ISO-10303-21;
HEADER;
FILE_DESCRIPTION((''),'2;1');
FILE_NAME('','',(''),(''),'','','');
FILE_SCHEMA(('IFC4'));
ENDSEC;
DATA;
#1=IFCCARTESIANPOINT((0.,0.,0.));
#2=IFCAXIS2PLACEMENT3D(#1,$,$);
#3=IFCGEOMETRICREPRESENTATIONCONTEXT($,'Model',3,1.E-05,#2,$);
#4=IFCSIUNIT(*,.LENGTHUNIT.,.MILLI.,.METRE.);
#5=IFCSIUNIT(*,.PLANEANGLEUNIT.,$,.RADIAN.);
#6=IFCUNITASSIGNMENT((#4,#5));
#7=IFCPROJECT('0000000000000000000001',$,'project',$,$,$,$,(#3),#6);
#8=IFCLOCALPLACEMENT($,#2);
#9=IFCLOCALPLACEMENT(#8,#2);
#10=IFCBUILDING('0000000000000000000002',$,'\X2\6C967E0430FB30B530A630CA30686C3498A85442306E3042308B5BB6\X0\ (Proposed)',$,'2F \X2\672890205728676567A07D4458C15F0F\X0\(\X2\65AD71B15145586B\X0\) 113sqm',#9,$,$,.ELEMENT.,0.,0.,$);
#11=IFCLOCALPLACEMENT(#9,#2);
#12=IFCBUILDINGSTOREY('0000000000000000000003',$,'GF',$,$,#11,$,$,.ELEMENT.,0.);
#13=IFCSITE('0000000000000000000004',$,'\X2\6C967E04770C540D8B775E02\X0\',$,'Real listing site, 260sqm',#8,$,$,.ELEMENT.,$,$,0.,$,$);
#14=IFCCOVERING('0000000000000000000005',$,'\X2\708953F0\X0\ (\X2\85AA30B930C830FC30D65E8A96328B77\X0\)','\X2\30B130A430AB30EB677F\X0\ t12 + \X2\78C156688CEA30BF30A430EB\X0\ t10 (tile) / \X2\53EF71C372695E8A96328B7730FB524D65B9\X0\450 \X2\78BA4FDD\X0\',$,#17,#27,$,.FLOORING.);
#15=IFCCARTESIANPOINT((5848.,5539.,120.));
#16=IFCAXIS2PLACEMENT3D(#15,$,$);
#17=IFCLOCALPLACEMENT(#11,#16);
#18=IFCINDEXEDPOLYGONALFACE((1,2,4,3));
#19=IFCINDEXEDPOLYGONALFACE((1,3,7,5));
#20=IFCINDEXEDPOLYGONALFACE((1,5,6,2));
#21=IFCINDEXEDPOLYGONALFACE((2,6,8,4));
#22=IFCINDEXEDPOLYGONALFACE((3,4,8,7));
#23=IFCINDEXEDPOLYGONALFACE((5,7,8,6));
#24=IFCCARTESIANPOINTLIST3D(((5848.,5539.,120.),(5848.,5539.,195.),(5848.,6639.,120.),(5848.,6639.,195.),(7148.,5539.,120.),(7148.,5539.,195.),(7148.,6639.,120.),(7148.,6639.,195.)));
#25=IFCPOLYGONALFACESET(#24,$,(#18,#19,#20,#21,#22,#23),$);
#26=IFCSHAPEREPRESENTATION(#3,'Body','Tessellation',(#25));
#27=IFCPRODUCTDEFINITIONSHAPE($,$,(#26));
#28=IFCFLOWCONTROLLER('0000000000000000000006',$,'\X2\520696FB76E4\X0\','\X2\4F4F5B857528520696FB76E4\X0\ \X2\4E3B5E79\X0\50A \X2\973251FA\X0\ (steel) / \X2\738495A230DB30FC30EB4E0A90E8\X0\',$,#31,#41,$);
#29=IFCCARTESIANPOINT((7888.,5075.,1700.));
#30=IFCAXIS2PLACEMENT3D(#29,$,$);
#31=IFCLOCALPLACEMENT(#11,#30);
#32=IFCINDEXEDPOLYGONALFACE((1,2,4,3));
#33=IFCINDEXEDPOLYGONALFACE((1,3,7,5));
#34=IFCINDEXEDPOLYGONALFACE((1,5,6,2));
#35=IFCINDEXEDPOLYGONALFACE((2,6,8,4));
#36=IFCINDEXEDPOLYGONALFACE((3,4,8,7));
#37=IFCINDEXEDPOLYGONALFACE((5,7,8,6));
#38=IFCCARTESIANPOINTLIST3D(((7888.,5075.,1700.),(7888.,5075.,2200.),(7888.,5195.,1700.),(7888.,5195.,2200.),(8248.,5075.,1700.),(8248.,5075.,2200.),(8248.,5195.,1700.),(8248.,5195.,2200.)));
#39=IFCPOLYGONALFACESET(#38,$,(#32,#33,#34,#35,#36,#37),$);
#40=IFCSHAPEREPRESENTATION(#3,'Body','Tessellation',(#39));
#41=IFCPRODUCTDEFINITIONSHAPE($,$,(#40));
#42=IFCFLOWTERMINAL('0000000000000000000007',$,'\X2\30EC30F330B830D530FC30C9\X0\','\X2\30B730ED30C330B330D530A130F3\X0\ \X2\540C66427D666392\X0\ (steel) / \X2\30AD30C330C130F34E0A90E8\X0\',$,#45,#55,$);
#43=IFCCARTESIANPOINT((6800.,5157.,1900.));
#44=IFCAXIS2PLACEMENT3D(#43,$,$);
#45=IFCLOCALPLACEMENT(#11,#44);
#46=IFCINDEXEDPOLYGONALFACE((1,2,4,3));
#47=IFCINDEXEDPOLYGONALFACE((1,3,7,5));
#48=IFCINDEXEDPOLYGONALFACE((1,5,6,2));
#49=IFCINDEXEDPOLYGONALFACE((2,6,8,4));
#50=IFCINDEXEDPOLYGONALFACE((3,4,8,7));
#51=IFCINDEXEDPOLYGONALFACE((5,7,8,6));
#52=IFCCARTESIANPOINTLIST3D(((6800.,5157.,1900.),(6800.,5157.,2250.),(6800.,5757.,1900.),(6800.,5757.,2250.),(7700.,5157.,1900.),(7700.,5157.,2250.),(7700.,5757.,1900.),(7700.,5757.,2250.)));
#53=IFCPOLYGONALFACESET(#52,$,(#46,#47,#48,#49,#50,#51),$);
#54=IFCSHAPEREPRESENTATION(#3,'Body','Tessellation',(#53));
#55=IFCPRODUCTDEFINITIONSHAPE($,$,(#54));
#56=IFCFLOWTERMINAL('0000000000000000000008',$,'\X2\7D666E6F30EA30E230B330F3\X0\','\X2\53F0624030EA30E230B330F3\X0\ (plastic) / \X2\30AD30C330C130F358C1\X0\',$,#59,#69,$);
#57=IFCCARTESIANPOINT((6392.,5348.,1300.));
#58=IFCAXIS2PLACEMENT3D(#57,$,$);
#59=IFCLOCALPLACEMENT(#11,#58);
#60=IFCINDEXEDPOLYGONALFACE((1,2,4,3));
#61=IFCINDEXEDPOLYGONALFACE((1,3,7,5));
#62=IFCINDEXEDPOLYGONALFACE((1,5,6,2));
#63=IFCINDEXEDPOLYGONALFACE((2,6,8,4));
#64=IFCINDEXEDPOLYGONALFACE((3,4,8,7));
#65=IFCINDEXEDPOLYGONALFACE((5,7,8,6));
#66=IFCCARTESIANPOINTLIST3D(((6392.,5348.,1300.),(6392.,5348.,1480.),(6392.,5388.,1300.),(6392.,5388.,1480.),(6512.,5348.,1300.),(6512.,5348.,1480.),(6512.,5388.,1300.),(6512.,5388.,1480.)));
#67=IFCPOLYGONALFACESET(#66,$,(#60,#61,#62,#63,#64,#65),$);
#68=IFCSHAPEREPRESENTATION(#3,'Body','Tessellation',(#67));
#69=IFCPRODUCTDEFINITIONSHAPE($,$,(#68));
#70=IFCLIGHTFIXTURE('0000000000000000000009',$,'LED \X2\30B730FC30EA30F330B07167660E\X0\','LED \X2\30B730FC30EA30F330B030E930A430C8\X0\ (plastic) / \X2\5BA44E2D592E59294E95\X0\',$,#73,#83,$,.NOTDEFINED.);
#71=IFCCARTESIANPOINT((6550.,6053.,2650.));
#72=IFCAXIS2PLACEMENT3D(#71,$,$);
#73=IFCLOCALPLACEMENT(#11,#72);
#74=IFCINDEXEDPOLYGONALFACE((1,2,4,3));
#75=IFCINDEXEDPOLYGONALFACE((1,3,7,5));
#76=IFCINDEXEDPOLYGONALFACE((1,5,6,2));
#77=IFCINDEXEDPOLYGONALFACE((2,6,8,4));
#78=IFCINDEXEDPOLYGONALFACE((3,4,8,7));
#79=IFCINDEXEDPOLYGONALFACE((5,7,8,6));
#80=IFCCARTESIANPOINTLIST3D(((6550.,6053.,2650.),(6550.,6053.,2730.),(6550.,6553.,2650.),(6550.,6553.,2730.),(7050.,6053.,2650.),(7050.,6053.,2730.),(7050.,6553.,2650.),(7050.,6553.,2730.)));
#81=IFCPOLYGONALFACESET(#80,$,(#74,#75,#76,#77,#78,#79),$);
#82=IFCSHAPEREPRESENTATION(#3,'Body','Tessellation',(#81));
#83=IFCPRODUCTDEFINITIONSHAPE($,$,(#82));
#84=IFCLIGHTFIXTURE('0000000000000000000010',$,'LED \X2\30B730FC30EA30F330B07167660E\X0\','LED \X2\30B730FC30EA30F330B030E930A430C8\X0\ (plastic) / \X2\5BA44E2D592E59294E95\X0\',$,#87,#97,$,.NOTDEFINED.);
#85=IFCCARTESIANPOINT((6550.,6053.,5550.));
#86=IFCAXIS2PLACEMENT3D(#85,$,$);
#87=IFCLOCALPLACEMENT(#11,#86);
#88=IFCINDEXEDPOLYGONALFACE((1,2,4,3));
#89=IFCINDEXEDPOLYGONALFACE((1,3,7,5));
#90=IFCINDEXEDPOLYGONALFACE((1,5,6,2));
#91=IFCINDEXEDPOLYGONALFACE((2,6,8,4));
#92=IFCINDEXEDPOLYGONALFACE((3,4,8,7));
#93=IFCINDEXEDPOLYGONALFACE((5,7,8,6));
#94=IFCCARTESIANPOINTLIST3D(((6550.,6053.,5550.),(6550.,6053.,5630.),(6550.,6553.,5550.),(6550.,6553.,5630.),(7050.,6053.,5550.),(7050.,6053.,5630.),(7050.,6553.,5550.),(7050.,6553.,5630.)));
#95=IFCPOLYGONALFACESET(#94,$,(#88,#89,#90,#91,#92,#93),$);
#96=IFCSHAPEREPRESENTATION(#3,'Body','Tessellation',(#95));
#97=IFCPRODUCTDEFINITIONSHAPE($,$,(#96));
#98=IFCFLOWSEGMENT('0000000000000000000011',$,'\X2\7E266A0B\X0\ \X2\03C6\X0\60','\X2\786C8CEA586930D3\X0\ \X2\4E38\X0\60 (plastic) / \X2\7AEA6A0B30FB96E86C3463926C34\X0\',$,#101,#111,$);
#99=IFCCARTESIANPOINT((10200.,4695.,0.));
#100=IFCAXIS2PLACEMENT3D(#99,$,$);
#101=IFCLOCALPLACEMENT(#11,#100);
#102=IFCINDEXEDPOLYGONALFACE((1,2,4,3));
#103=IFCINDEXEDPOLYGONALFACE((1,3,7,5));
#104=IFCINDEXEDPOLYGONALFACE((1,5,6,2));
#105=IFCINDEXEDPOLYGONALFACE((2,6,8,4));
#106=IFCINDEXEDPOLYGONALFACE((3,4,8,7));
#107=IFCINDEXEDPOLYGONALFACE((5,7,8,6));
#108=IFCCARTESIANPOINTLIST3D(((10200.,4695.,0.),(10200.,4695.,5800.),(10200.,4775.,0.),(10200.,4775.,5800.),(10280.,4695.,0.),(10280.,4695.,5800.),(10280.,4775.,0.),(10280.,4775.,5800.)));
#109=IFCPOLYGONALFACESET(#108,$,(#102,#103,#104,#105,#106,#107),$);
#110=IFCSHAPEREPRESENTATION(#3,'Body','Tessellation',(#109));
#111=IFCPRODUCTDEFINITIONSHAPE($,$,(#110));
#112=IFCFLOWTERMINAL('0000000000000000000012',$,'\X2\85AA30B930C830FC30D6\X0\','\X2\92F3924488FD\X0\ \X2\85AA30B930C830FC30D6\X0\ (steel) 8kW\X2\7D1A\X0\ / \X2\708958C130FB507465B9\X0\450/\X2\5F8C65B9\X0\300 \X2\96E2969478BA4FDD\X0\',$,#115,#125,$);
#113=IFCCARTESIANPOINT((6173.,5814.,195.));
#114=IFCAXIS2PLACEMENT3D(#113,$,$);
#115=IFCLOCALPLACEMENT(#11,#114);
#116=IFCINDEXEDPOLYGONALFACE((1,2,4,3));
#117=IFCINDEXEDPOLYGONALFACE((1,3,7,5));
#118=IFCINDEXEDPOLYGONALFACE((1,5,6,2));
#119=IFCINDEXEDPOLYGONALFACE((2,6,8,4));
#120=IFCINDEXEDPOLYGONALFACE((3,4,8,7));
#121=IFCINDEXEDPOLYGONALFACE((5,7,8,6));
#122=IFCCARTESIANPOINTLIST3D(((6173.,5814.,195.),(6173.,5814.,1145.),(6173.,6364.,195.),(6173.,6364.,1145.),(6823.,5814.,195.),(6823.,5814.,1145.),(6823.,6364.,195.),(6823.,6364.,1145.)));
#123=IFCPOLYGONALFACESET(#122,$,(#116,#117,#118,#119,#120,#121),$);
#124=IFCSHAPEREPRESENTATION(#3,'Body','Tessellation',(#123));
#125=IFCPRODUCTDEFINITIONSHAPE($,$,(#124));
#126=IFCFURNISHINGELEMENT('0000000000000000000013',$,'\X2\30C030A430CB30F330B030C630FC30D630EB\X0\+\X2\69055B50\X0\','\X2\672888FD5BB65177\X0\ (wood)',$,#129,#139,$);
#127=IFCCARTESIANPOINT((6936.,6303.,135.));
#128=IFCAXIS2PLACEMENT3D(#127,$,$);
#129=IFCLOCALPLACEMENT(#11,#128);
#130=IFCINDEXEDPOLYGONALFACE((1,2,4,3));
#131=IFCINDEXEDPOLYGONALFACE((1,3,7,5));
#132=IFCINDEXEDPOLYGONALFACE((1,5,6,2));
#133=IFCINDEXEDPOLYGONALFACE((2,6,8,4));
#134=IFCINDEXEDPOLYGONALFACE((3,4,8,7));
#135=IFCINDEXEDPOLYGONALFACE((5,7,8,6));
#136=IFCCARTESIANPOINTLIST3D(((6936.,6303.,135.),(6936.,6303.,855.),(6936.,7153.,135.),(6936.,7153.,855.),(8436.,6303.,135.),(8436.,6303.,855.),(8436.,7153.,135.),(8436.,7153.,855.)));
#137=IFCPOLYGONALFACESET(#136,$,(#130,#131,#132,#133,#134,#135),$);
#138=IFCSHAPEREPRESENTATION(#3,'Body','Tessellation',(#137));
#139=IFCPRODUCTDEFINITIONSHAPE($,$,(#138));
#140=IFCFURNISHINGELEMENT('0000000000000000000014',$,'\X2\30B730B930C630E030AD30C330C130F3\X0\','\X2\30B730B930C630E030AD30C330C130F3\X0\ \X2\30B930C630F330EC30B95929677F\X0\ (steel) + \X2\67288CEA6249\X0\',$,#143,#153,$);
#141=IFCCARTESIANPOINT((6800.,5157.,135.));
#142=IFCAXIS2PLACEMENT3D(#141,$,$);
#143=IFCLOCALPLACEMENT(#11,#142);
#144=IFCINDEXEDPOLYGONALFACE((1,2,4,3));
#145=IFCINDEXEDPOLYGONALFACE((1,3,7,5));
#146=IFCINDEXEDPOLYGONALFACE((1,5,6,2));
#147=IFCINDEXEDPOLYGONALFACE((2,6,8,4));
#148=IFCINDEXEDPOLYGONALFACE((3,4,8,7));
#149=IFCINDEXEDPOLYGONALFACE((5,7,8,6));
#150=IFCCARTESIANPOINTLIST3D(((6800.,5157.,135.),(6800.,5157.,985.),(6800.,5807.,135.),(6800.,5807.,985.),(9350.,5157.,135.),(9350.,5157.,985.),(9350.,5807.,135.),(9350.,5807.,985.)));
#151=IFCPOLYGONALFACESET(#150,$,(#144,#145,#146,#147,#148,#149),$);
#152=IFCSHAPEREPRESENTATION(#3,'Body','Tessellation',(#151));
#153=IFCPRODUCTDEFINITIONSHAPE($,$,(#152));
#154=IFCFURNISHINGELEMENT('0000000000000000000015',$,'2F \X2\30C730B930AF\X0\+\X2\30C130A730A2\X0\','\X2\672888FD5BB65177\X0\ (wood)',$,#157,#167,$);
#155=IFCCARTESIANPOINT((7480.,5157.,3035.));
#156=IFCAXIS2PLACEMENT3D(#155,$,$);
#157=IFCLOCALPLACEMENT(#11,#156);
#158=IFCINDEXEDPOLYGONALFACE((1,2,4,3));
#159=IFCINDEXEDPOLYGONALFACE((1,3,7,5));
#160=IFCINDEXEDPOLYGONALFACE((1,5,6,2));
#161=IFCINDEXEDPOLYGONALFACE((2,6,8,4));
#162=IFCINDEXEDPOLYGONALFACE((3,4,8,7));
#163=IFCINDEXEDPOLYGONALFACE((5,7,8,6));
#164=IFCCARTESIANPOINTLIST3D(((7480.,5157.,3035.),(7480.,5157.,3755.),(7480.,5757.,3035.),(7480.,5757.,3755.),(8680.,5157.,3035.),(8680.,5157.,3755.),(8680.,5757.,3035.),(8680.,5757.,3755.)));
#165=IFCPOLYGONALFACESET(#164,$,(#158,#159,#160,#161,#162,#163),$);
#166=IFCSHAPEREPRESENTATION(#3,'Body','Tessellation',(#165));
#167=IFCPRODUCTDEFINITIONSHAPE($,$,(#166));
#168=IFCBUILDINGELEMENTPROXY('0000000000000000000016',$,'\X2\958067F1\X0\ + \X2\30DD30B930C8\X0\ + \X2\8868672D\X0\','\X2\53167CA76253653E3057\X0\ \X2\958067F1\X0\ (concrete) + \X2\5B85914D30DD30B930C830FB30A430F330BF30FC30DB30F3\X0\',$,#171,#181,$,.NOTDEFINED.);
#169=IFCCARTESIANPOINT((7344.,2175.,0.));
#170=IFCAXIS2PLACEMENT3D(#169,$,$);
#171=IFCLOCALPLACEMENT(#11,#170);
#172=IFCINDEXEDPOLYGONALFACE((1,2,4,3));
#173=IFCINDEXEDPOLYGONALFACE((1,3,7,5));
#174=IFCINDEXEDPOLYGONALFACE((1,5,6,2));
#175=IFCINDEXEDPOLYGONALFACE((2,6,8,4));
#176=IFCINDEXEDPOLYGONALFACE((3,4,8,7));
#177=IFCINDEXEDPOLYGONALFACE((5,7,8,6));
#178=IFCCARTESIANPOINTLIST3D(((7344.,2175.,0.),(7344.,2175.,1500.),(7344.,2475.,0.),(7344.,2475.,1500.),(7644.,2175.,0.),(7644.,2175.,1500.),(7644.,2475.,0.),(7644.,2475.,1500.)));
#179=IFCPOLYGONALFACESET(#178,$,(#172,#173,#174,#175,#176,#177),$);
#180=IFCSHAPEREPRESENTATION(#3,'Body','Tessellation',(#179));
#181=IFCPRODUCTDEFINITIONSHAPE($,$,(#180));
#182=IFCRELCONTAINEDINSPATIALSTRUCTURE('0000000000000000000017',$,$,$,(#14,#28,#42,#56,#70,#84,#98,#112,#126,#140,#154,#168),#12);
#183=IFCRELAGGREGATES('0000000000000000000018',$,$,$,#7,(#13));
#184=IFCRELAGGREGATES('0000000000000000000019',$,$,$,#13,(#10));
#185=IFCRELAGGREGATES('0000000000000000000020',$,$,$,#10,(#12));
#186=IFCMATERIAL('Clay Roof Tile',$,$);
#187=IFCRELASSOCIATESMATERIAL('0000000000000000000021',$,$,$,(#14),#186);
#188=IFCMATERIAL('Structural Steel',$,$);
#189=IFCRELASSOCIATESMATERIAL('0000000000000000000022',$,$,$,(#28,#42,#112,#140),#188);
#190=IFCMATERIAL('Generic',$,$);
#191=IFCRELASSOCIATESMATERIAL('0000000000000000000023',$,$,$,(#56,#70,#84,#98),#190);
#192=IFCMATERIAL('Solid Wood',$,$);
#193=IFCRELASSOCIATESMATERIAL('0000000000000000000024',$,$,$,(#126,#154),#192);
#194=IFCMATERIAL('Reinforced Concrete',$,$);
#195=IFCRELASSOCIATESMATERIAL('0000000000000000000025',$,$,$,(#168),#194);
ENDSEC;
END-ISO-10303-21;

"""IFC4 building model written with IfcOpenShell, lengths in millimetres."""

from ifc_helpers import new_model, si_unit, frame, frame_2d, origin, place, context, project, spatial, rectangle, extrude, material, element, save


model = new_model("IFC4")

# Units and contexts
model_context = context("Model", 3, precision=1e-05, world=origin())
ifc_project = project(units=[si_unit("LENGTHUNIT", "METRE", prefix="MILLI"), si_unit("PLANEANGLEUNIT", "RADIAN")], contexts=[model_context])

# Site, building, storey
site_placement = place(None, origin())
site = spatial("IfcSite", under=ifc_project, at=site_placement, Name="沖縄県名護市", ObjectType="Real listing site, 260sqm", CompositionType="ELEMENT", RefElevation=0.0)
building_placement = place(site_placement, origin())
building = spatial("IfcBuilding", under=site, at=building_placement, Name="沖縄・サウナと水風呂のある家 (Proposed)", ObjectType="2F 木造在来枠組壁式(断熱充填) 113sqm", CompositionType="ELEMENT", ElevationOfRefHeight=0.0, ElevationOfTerrain=0.0)
storey_placement = place(building_placement, origin())
storey = spatial("IfcBuildingStorey", under=building, at=storey_placement, Name="GF", CompositionType="ELEMENT", Elevation=0.0)

# Shared definitions
ifc_material_1 = material(Name="Solid Wood")

# Shared definitions
ifc_material_2 = material(Name="Structural Steel")

# Covering
ifc_material_3 = material(Name="Reinforced Concrete")
ifc_material_4 = material(Name="Clay Roof Tile")
covering_1_placement = place(storey_placement, frame((5848.0, 5539.0, 120.0)))
element("IfcCovering", 1, at=covering_1_placement, inside=storey, material=ifc_material_4, Name="炉台 (薪ストーブ床防護)", Description="ケイカル板 t12 + 磁器質タイル t10 (tile) / 可燃物床防護・前方450 確保", PredefinedType="FLOORING", context=model_context, shape_type="SweptSolid", body=[
    extrude(rectangle(XDim=1300.0, YDim=1100.0, at=frame_2d((650.0, 550.0))), frame((5848.0, 5539.0, 120.0)), (0.0, 0.0, 1.0), 75.0),
])

# Flow controller
flow_controller_placement = place(storey_placement, frame((7888.0, 5075.0, 1700.0)))
element("IfcFlowController", 2, at=flow_controller_placement, inside=storey, material=ifc_material_2, Name="分電盤", Description="住宅用分電盤 主幹50A 露出 (steel) / 玄関ホール上部", context=model_context, shape_type="SweptSolid", body=[
    extrude(rectangle(XDim=360.0, YDim=120.0, at=frame_2d((180.0, 60.0))), frame((7888.0, 5075.0, 1700.0)), (0.0, 0.0, 1.0), 500.0),
])

# Flow terminals
flow_terminal_1_placement = place(storey_placement, frame((6800.0, 5157.0, 1900.0)))
element("IfcFlowTerminal", 3, at=flow_terminal_1_placement, inside=storey, material=ifc_material_2, Name="レンジフード", Description="シロッコファン 同時給排 (steel) / キッチン上部", context=model_context, shape_type="SweptSolid", body=[
    extrude(rectangle(XDim=900.0, YDim=600.0, at=frame_2d((450.0, 300.0))), frame((6800.0, 5157.0, 1900.0)), (0.0, 0.0, 1.0), 350.0),
])
ifc_material_5 = material(Name="Generic")
flow_terminal_2_placement = place(storey_placement, frame((6392.0, 5348.0, 1300.0)))
element("IfcFlowTerminal", 4, at=flow_terminal_2_placement, inside=storey, material=ifc_material_5, Name="給湯リモコン", Description="台所リモコン (plastic) / キッチン壁", context=model_context, shape_type="SweptSolid", body=[
    extrude(rectangle(XDim=120.0, YDim=40.0, at=frame_2d((60.0, 20.0))), frame((6392.0, 5348.0, 1300.0)), (0.0, 0.0, 1.0), 180.0),
])

# Light fixtures
light_fixture_1_placement = place(storey_placement, frame((6550.0, 6053.0, 2650.0)))
element("IfcLightFixture", 5, at=light_fixture_1_placement, inside=storey, material=ifc_material_5, Name="LED シーリング照明", Description="LED シーリングライト (plastic) / 室中央天井", PredefinedType="NOTDEFINED", context=model_context, shape_type="SweptSolid", body=[
    extrude(rectangle(XDim=500.0, YDim=500.0, at=frame_2d((250.0, 250.0))), frame((6550.0, 6053.0, 2650.0)), (0.0, 0.0, 1.0), 80.0),
])
light_fixture_2_placement = place(storey_placement, frame((6550.0, 6053.0, 5550.0)))
element("IfcLightFixture", 6, at=light_fixture_2_placement, inside=storey, material=ifc_material_5, Name="LED シーリング照明", Description="LED シーリングライト (plastic) / 室中央天井", PredefinedType="NOTDEFINED", context=model_context, shape_type="SweptSolid", body=[
    extrude(rectangle(XDim=500.0, YDim=500.0, at=frame_2d((250.0, 250.0))), frame((6550.0, 6053.0, 5550.0)), (0.0, 0.0, 1.0), 80.0),
])

# Flow segment
flow_segment_placement = place(storey_placement, frame((10200.0, 4695.0, 0.0)))
element("IfcFlowSegment", 7, at=flow_segment_placement, inside=storey, material=ifc_material_5, Name="縦樋 φ60", Description="硬質塩ビ 丸60 (plastic) / 竪樋・雨水排水", context=model_context, shape_type="SweptSolid", body=[
    extrude(rectangle(XDim=80.0, YDim=80.0, at=frame_2d((40.0, 40.0))), frame((10200.0, 4695.0, 0.0)), (0.0, 0.0, 1.0), 5800.0),
])

# Flow terminal
flow_terminal_3_placement = place(storey_placement, frame((6173.0, 5814.0, 195.0)))
element("IfcFlowTerminal", 8, at=flow_terminal_3_placement, inside=storey, material=ifc_material_2, Name="薪ストーブ", Description="鋳鉄製 薪ストーブ (steel) 8kW級 / 炉壁・側方450/後方300 離隔確保", context=model_context, shape_type="SweptSolid", body=[
    extrude(rectangle(XDim=650.0, YDim=550.0, at=frame_2d((325.0, 275.0))), frame((6173.0, 5814.0, 195.0)), (0.0, 0.0, 1.0), 950.0),
])

# Furnishing elements
furnishing_1_placement = place(storey_placement, frame((6936.0, 6303.0, 135.0)))
element("IfcFurnishingElement", 9, at=furnishing_1_placement, inside=storey, material=ifc_material_1, Name="ダイニングテーブル+椅子", Description="木製家具 (wood)", context=model_context, shape_type="SweptSolid", body=[
    extrude(rectangle(XDim=1500.0, YDim=850.0, at=frame_2d((750.0, 425.0))), frame((6936.0, 6303.0, 135.0)), (0.0, 0.0, 1.0), 720.0),
])
furnishing_2_placement = place(storey_placement, frame((6800.0, 5157.0, 135.0)))
element("IfcFurnishingElement", 10, at=furnishing_2_placement, inside=storey, material=ifc_material_2, Name="システムキッチン", Description="システムキッチン ステンレス天板 (steel) + 木質扉", context=model_context, shape_type="SweptSolid", body=[
    extrude(rectangle(XDim=2550.0, YDim=650.0, at=frame_2d((1275.0, 325.0))), frame((6800.0, 5157.0, 135.0)), (0.0, 0.0, 1.0), 850.0),
])
furnishing_3_placement = place(storey_placement, frame((7480.0, 5157.0, 3035.0)))
element("IfcFurnishingElement", 11, at=furnishing_3_placement, inside=storey, material=ifc_material_1, Name="2F デスク+チェア", Description="木製家具 (wood)", context=model_context, shape_type="SweptSolid", body=[
    extrude(rectangle(XDim=1200.0, YDim=600.0, at=frame_2d((600.0, 300.0))), frame((7480.0, 5157.0, 3035.0)), (0.0, 0.0, 1.0), 720.0),
])

# Building element proxy
proxy_placement = place(storey_placement, frame((7344.0, 2175.0, 0.0)))
element("IfcBuildingElementProxy", 12, at=proxy_placement, inside=storey, material=ifc_material_3, Name="門柱 + ポスト + 表札", Description="化粧打放し 門柱 (concrete) + 宅配ポスト・インターホン", PredefinedType="NOTDEFINED", context=model_context, shape_type="SweptSolid", body=[
    extrude(rectangle(XDim=300.0, YDim=300.0, at=frame_2d((150.0, 150.0))), frame((7344.0, 2175.0, 0.0)), (0.0, 0.0, 1.0), 1500.0),
])

save(model, "model.ifc")
